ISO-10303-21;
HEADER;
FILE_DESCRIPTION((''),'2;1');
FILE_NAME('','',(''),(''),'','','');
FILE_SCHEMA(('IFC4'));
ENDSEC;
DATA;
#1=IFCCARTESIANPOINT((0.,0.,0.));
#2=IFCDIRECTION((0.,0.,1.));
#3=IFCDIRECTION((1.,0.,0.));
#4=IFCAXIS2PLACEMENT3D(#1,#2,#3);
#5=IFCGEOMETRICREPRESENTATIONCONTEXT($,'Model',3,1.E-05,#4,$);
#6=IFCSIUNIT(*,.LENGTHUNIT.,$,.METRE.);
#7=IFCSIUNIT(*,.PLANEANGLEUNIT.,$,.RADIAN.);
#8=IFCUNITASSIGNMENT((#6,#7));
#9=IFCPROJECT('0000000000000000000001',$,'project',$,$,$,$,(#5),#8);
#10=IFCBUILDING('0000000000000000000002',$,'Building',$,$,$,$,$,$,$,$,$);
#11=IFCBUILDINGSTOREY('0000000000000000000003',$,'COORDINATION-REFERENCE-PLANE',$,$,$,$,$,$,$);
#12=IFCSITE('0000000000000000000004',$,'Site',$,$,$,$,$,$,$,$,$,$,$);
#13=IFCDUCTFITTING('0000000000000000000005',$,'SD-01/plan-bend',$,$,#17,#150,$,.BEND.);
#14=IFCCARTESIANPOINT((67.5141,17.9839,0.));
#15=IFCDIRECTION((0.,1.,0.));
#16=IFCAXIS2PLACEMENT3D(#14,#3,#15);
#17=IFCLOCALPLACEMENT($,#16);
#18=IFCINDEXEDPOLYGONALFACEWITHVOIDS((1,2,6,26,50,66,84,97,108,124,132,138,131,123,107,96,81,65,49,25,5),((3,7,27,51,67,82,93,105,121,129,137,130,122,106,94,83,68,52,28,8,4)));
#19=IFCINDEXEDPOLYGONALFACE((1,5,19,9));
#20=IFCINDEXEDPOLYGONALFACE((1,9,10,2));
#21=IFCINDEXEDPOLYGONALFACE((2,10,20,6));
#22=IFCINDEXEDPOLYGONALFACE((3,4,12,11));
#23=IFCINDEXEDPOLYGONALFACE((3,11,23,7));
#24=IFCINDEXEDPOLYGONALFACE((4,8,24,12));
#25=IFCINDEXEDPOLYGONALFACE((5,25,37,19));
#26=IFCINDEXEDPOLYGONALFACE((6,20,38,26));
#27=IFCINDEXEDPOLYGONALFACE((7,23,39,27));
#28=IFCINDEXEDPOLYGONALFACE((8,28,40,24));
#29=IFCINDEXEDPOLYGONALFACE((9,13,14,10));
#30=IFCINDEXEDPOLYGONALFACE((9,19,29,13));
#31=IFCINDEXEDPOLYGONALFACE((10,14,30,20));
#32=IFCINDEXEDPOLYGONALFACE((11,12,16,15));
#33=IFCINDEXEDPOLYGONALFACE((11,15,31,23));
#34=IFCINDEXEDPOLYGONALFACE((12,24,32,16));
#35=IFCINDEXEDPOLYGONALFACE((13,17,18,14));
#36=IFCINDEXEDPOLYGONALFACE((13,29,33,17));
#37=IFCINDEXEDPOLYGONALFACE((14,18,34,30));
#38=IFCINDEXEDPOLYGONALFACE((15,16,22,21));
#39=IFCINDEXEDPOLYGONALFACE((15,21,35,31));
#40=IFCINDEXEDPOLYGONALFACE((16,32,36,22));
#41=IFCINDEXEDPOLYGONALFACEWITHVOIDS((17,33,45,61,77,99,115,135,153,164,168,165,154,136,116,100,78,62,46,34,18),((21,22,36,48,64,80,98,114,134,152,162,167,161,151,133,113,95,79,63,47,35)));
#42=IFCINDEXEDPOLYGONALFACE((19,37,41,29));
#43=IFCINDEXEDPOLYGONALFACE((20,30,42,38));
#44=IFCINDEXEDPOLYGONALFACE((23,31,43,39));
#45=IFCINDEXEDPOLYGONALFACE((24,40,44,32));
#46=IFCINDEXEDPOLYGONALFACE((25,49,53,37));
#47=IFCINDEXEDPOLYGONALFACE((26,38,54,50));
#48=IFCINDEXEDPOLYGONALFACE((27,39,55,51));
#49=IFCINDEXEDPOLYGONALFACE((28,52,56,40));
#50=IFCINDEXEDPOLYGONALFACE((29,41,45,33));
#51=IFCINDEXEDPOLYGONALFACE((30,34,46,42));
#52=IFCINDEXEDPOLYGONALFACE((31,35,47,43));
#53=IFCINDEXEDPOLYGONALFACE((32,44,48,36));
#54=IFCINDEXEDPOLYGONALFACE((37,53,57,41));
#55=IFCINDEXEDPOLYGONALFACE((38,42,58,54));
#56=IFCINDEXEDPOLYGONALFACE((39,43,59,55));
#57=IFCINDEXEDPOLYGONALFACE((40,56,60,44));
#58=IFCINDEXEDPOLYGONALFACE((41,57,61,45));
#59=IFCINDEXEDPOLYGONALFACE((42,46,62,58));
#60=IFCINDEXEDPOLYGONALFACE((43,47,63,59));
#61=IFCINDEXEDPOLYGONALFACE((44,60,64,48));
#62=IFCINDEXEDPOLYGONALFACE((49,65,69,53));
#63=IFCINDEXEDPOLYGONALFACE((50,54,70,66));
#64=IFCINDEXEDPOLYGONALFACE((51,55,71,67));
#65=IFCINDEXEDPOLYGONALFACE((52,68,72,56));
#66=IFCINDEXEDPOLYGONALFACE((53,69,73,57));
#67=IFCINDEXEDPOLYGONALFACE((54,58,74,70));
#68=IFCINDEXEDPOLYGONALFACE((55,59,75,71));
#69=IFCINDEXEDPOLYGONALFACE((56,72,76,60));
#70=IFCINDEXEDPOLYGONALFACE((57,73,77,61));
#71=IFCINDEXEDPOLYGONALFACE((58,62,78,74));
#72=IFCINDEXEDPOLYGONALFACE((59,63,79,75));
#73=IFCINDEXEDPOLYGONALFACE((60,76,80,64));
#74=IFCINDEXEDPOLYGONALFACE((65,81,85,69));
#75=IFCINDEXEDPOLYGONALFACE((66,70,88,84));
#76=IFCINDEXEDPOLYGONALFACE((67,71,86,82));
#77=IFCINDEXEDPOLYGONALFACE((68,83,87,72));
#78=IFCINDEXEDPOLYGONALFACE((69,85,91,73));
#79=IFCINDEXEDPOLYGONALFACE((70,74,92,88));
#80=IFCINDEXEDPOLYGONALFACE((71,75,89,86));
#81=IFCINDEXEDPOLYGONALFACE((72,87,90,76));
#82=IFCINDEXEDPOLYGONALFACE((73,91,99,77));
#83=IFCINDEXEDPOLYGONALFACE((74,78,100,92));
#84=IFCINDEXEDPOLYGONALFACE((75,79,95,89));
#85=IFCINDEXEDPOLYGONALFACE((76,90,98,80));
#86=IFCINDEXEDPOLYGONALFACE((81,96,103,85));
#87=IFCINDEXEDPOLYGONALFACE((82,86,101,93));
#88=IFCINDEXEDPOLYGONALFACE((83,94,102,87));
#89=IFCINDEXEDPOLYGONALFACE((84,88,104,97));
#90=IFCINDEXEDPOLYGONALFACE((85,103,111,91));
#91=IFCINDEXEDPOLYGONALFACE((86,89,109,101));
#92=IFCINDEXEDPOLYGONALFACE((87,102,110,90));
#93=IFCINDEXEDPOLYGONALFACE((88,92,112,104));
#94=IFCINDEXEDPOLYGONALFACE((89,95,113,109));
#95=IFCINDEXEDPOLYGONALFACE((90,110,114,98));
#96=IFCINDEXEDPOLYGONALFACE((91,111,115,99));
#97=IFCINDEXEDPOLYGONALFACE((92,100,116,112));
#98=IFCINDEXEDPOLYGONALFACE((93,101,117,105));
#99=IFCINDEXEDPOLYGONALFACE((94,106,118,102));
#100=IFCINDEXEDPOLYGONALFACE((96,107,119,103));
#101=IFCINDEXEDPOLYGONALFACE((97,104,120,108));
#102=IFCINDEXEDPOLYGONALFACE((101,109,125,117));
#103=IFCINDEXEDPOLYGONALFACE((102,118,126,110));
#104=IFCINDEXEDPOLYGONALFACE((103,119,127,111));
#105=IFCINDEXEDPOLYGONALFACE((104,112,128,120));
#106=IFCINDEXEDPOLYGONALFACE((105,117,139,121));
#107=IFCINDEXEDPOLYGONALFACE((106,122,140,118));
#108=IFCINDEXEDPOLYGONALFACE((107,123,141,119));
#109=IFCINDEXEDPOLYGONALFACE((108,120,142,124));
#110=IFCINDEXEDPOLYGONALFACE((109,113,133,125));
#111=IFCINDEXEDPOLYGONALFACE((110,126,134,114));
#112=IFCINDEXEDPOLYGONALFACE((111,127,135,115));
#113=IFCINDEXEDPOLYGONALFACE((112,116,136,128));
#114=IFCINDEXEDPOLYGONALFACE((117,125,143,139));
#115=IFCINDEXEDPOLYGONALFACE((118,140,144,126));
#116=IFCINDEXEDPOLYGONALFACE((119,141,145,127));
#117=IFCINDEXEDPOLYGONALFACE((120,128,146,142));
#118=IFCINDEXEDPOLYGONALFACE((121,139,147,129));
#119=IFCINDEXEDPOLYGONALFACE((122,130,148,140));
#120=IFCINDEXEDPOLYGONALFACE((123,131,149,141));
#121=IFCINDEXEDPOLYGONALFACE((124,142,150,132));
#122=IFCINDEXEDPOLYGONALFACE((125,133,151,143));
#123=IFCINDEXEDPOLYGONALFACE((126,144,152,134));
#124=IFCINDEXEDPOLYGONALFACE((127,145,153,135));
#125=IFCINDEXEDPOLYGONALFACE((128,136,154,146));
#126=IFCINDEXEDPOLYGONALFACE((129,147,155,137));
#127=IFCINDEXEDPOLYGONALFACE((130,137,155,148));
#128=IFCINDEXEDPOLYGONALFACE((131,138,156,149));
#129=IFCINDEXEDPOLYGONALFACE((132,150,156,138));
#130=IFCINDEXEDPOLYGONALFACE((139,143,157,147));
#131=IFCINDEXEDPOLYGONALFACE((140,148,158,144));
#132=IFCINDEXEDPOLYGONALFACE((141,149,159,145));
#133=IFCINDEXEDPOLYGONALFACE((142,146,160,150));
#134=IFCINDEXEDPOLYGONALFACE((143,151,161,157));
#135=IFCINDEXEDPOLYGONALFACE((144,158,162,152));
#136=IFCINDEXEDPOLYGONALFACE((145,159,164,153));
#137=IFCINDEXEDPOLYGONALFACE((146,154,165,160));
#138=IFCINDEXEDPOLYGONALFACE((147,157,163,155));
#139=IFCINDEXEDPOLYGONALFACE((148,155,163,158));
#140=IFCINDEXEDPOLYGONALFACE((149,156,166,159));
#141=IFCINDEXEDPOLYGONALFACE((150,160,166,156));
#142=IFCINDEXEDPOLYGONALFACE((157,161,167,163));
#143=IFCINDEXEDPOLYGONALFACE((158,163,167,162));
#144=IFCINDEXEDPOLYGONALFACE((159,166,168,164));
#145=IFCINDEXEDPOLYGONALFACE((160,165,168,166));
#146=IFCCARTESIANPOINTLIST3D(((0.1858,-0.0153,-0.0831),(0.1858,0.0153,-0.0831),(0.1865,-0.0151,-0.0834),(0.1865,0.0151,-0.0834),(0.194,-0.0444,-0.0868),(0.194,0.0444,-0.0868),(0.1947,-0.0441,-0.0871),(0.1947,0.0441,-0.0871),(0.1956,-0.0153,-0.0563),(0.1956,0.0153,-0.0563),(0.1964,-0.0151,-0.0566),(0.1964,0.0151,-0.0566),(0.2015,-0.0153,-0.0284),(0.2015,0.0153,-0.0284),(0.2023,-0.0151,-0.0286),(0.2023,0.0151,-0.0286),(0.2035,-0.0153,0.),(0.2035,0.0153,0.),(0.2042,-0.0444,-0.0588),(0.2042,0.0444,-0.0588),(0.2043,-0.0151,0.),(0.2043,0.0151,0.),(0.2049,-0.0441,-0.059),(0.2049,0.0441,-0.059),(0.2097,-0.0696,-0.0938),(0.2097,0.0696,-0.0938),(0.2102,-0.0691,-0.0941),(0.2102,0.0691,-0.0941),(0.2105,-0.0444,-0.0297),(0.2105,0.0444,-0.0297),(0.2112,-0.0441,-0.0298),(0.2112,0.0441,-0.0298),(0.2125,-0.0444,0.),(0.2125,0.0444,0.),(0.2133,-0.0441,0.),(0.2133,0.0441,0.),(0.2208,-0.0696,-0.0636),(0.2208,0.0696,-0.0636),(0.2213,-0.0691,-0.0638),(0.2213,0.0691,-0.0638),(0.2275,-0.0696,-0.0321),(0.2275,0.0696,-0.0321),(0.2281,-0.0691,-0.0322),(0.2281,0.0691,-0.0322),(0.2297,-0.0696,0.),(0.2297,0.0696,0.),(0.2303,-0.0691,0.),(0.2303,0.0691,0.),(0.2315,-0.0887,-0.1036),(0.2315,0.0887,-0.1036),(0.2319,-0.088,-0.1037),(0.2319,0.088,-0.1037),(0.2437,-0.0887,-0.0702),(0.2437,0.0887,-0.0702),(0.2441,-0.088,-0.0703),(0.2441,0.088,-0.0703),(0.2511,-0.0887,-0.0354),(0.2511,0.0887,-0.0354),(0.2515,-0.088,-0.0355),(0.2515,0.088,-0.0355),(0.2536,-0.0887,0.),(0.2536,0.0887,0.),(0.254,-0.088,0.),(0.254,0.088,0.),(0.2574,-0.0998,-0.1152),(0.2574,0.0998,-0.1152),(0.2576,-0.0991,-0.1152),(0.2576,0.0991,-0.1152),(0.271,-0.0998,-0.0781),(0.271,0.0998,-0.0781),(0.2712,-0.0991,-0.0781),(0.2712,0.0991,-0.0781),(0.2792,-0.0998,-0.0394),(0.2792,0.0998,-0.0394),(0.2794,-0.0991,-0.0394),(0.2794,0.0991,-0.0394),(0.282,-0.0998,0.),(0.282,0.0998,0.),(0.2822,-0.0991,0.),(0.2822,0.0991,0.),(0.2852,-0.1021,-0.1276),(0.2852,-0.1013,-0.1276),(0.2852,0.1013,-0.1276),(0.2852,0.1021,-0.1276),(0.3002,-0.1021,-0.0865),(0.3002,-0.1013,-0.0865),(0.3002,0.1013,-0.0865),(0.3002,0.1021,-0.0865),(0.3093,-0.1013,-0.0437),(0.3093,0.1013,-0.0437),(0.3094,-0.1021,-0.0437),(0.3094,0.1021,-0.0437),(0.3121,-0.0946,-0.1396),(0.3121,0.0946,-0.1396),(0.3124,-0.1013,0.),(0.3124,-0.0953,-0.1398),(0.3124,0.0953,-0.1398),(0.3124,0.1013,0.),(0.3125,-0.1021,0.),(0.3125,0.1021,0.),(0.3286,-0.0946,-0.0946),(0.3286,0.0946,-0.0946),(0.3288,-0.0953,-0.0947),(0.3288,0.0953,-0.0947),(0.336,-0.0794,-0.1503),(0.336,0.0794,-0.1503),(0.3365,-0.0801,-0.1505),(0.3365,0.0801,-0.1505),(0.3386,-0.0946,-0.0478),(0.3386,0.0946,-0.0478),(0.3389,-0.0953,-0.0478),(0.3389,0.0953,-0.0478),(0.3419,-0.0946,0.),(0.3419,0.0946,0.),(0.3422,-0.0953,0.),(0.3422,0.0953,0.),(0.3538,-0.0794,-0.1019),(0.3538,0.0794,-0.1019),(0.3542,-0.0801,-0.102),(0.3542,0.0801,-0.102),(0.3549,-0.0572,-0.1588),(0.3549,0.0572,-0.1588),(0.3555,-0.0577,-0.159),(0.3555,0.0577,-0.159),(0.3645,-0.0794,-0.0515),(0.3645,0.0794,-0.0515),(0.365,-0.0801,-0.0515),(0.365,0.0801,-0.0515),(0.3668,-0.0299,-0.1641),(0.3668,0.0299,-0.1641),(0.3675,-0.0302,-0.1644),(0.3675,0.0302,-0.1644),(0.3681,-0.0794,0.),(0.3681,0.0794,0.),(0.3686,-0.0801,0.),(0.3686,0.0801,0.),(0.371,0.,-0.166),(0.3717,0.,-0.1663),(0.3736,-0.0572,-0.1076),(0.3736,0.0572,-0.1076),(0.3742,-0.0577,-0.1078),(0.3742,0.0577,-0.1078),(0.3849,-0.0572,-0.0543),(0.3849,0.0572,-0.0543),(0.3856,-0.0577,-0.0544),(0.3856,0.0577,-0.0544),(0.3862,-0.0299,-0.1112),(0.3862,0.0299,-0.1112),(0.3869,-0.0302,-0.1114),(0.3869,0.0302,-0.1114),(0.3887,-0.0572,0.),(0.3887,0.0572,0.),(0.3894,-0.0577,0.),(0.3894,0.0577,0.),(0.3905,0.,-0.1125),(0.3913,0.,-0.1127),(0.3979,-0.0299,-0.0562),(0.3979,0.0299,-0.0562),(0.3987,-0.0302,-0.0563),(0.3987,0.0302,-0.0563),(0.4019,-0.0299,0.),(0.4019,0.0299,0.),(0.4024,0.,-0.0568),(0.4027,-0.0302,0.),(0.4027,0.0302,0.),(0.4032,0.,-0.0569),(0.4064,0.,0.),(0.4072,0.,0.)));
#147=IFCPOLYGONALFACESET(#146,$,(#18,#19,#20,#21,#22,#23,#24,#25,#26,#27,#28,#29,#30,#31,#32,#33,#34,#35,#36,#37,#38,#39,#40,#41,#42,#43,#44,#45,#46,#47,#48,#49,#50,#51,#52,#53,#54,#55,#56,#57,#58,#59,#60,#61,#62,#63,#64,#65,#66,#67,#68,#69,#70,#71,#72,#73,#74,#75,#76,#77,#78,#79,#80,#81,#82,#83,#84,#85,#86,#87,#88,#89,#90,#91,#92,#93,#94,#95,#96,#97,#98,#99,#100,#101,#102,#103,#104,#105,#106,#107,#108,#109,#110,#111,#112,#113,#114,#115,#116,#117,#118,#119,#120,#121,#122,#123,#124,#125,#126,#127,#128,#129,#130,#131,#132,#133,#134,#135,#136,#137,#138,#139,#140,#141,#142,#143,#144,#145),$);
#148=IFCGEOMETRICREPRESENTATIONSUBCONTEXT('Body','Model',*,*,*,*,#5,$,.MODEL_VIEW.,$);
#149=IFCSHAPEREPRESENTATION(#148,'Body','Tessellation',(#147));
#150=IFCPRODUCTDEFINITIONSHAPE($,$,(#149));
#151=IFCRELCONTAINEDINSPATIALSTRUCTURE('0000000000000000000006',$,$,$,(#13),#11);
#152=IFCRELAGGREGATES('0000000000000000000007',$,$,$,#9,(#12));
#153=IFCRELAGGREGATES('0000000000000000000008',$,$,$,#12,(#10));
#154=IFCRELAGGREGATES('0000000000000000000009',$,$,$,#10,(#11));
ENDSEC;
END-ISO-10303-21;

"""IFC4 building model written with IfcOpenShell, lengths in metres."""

from ifc_helpers import new_model, entity, si_unit, frame, origin_with_axes, place, context, subcontext, project, spatial, element, save


model = new_model("IFC4")

# Units and contexts
model_context = context("Model", 3, precision=1e-05, world=origin_with_axes())
body_context_1 = subcontext(model_context, "Body", "Model", "MODEL_VIEW")
ifc_project = project(units=[si_unit("LENGTHUNIT", "METRE"), si_unit("PLANEANGLEUNIT", "RADIAN")], contexts=[model_context])

# Site, building, storey
site = spatial("IfcSite", under=ifc_project, Name="Site")
building = spatial("IfcBuilding", under=site, Name="Building")
storey = spatial("IfcBuildingStorey", under=building, Name="COORDINATION-REFERENCE-PLANE")

# Duct fitting
duct_fitting_1_placement = place(None, frame((67.5141, 17.9839, 0.0), z_axis=(1.0, 0.0, 0.0), x_axis=(0.0, 1.0, 0.0)))
element("IfcDuctFitting", 1, at=duct_fitting_1_placement, inside=storey, Name="SD-01/plan-bend", PredefinedType="BEND", context=body_context_1, shape_type="SweptSolid", body=[
    entity("IfcRevolvedAreaSolid", entity("IfcCircleHollowProfileDef", "AREA", None, entity("IfcAxis2Placement2D", entity("IfcCartesianPoint", [0.3048, 0.0])), 0.1024, 0.0008), entity("IfcAxis2Placement3D", entity("IfcCartesianPoint", [0.0, 0.0, 0.0]), entity("IfcDirection", [0.0, 0.0, 1.0]), entity("IfcDirection", [1.0, 0.0, 0.0])), entity("IfcAxis1Placement", entity("IfcCartesianPoint", [0.0, 0.0, 0.0]), entity("IfcDirection", [0.0, 1.0, 0.0])), 0.420676),
])

save(model, "model.ifc")
